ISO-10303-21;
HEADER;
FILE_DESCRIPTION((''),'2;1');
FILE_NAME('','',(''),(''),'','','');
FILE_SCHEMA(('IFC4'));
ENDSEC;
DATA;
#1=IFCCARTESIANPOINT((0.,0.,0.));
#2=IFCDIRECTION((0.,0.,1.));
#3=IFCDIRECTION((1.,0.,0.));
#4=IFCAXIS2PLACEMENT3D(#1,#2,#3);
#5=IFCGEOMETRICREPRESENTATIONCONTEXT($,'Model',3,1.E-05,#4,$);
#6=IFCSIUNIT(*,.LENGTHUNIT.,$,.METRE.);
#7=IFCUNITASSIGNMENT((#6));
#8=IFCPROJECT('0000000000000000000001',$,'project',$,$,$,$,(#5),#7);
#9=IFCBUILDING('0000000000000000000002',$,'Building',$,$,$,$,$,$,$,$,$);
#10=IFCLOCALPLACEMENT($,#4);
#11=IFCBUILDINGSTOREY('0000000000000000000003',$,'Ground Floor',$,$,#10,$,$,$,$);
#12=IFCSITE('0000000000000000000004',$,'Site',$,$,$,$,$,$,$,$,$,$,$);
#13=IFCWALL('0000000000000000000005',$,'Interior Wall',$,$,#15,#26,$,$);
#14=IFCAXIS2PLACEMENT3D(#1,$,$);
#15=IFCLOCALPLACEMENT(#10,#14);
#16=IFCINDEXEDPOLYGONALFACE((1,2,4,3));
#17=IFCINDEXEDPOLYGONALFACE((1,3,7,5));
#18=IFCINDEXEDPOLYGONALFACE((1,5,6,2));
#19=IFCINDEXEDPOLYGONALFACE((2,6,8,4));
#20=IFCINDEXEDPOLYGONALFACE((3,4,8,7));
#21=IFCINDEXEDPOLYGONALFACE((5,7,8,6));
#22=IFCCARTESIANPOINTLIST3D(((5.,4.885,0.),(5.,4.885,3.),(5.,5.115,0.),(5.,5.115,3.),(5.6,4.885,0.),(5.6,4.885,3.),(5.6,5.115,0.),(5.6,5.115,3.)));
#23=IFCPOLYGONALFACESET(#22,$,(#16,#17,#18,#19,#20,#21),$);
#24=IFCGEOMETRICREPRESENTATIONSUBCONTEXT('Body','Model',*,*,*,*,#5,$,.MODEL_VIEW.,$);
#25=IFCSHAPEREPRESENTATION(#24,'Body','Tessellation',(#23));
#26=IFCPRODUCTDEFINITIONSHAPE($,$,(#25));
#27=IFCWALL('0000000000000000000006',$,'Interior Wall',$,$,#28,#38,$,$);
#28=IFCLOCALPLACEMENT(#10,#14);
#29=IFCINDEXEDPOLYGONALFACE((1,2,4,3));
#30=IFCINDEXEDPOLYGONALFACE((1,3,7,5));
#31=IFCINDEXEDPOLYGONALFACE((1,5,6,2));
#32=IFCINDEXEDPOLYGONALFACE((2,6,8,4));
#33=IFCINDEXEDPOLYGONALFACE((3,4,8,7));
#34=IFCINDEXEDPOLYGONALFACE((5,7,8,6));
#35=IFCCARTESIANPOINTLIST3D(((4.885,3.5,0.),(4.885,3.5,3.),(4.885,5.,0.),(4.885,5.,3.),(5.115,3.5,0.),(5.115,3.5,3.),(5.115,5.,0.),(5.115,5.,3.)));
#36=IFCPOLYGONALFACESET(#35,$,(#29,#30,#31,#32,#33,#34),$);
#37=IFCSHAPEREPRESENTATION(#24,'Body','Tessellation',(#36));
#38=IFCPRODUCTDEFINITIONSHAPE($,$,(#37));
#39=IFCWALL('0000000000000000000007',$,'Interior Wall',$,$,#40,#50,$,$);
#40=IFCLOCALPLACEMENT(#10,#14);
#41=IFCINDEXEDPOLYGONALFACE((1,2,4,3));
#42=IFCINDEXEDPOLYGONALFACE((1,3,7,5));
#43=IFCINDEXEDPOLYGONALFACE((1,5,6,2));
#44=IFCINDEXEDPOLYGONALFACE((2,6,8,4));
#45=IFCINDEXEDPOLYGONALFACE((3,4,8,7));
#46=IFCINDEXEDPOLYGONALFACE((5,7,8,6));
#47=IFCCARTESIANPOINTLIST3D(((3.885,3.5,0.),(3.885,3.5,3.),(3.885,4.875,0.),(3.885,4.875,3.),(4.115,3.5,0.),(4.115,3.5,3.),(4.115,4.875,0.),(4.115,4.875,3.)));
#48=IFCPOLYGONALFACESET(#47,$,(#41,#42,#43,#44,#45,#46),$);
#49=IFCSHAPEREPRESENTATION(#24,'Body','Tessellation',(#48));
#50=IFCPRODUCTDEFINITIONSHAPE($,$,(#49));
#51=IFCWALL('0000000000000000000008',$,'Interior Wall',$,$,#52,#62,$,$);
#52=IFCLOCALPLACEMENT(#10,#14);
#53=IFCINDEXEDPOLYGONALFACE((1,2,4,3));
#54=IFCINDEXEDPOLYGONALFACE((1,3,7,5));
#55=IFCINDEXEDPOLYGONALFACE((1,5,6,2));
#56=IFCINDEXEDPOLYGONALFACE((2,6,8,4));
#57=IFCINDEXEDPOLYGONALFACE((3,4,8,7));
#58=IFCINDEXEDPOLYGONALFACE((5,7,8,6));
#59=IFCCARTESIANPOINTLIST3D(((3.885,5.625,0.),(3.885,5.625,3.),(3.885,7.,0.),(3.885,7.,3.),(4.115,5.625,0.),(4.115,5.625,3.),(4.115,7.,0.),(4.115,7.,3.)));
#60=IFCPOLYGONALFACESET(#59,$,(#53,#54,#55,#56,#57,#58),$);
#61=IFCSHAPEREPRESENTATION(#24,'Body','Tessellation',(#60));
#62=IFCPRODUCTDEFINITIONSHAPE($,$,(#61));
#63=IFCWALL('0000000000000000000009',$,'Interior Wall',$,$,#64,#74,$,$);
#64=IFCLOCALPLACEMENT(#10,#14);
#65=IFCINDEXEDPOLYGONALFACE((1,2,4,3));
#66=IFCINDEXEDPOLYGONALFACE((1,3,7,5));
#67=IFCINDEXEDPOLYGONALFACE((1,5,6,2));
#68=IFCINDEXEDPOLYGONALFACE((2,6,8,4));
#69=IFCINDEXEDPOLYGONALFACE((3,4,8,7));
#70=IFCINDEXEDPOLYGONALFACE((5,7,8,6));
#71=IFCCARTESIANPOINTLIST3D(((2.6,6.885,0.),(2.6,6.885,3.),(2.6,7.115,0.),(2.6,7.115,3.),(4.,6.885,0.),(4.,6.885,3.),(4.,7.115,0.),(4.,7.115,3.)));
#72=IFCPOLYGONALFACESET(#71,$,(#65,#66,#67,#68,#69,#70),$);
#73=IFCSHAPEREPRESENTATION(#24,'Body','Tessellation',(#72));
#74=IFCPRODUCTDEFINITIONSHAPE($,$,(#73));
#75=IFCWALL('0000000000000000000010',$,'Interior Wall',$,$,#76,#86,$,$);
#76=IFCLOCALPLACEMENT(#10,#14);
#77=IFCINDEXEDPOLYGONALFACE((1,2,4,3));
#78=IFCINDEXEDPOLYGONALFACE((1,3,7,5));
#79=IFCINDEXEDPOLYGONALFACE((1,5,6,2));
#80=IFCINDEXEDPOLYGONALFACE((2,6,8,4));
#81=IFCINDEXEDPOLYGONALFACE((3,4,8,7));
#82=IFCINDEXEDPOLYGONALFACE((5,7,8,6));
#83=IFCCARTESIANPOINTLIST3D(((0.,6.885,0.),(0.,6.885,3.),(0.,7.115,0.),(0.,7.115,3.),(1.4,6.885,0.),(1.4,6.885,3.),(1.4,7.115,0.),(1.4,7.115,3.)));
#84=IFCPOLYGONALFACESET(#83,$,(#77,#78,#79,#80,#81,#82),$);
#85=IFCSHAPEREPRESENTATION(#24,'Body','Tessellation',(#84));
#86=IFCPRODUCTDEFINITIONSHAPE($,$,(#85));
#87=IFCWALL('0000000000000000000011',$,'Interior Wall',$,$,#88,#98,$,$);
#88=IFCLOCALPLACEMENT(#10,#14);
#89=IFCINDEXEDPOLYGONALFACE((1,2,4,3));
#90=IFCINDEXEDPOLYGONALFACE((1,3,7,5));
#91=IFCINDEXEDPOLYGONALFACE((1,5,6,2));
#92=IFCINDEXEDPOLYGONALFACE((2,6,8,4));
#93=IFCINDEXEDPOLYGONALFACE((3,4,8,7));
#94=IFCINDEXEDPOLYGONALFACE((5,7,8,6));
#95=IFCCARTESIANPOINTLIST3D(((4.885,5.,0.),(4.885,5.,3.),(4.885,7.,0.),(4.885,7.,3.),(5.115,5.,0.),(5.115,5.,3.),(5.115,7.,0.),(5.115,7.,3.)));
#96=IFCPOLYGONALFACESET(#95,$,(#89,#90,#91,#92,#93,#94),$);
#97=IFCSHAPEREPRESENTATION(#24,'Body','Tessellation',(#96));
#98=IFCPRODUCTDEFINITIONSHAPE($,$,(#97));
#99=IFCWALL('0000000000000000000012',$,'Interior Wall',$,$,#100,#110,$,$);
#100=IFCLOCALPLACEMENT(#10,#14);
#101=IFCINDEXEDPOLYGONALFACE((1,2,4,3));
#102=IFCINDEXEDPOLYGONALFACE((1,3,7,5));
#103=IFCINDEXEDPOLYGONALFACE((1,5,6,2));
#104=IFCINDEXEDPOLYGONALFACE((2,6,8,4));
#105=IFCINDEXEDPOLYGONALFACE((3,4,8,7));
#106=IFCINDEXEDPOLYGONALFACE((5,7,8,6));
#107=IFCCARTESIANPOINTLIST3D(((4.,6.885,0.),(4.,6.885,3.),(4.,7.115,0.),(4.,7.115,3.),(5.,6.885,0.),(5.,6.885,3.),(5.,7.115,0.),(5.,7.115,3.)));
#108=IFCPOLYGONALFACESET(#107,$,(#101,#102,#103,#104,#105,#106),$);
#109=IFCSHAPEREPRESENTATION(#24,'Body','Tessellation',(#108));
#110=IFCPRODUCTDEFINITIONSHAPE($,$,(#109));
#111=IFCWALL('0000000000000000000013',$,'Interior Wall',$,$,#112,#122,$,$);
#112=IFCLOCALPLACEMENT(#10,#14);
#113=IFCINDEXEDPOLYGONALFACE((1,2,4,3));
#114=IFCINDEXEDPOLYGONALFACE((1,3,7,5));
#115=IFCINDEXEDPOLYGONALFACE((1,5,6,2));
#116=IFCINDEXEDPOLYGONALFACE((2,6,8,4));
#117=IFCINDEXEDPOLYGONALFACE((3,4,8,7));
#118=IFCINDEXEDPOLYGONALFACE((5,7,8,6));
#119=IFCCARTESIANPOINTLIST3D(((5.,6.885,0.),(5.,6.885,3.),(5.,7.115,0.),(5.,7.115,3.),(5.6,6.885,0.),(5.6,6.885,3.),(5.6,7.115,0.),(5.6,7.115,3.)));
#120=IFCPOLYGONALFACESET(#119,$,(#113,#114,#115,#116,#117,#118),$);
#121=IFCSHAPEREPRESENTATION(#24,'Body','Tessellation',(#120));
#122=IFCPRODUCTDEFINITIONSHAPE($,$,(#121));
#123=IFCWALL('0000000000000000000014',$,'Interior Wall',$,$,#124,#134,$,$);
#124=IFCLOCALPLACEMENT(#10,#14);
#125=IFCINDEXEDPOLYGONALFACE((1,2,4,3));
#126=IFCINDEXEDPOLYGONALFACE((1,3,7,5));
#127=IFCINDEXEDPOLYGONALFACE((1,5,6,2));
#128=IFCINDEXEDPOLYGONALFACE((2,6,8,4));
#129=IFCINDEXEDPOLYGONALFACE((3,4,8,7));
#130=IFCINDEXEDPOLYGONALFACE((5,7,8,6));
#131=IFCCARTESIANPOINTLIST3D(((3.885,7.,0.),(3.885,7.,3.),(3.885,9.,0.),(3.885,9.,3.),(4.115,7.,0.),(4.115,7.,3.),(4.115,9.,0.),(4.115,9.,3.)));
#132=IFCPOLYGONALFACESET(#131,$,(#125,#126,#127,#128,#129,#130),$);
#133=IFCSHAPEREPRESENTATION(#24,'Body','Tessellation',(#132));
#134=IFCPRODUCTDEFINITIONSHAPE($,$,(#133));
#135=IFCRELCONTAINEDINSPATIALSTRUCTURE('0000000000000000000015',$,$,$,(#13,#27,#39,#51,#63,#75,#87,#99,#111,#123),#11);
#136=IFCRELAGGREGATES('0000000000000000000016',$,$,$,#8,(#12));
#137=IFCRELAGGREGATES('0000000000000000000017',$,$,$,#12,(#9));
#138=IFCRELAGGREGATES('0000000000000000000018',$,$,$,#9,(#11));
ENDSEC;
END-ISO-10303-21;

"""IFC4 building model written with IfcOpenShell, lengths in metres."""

from ifc_helpers import new_model, si_unit, frame, origin_with_axes, place, context, subcontext, project, spatial, indexed_curve, outline, extrude, element, save


model = new_model("IFC4")

# Units and contexts
model_context = context("Model", 3, precision=1e-05, world=origin_with_axes())
body_context = subcontext(model_context, "Body", "Model", "MODEL_VIEW")
ifc_project = project(units=[si_unit("LENGTHUNIT", "METRE")], contexts=[model_context])

# Site, building, storey
site = spatial("IfcSite", under=ifc_project, Name="Site")
building = spatial("IfcBuilding", under=site, Name="Building")
storey_placement = place(None, origin_with_axes())
storey = spatial("IfcBuildingStorey", under=building, at=storey_placement, Name="Ground Floor")

# Walls
wall_1_placement = place(storey_placement, frame((5.6, 5.0, 0.0), z_axis=(0.0, 0.0, 1.0), x_axis=(-1.0, 0.0, 0.0)))
element("IfcWall", 1, at=wall_1_placement, inside=storey, Name="Interior Wall", context=body_context, shape_type="SweptSolid", body=[
    extrude(outline(indexed_curve([(0.0, 0.0), (0.0, 0.23), (0.6, 0.23), (0.6, 0.0), (0.0, 0.0)], self_intersect=False)), frame((0.0, -0.115, 0.0), z_axis=(0.0, 0.0, 1.0), x_axis=(1.0, 0.0, 0.0)), (0.0, 0.0, 1.0), 3.0),
])
wall_2_placement = place(storey_placement, frame((5.0, 5.0, 0.0), z_axis=(0.0, 0.0, 1.0), x_axis=(0.0, -1.0, 0.0)))
element("IfcWall", 2, at=wall_2_placement, inside=storey, Name="Interior Wall", context=body_context, shape_type="SweptSolid", body=[
    extrude(outline(indexed_curve([(0.0, 0.0), (0.0, 0.23), (1.5, 0.23), (1.5, 0.0), (0.0, 0.0)], self_intersect=False)), frame((0.0, -0.115, 0.0), z_axis=(0.0, 0.0, 1.0), x_axis=(1.0, 0.0, 0.0)), (0.0, 0.0, 1.0), 3.0),
])
for number, where, z_axis, x_axis, name in (
    (3, (4.0, 3.5, 0.0), (0.0, 0.0, 1.0), (0.0, 1.0, 0.0), "Interior Wall"),
    (4, (4.0, 5.625, 0.0), (0.0, 0.0, 1.0), (0.0, 1.0, 0.0), "Interior Wall"),
):
    element("IfcWall", number, at=place(storey_placement, frame(where, z_axis=z_axis, x_axis=x_axis)), inside=storey, Name=name, context=body_context, shape_type="SweptSolid", body=[
        extrude(outline(indexed_curve([(0.0, 0.0), (0.0, 0.23), (1.375, 0.23), (1.375, 0.0), (0.0, 0.0)], self_intersect=False)), frame((0.0, -0.115, 0.0), z_axis=(0.0, 0.0, 1.0), x_axis=(1.0, 0.0, 0.0)), (0.0, 0.0, 1.0), 3.0),
    ])
for number, where, z_axis, x_axis, name in (
    (5, (4.0, 7.0, 0.0), (0.0, 0.0, 1.0), (-1.0, 0.0, 0.0), "Interior Wall"),
    (6, (1.4, 7.0, 0.0), (0.0, 0.0, 1.0), (-1.0, 0.0, 0.0), "Interior Wall"),
):
    element("IfcWall", number, at=place(storey_placement, frame(where, z_axis=z_axis, x_axis=x_axis)), inside=storey, Name=name, context=body_context, shape_type="SweptSolid", body=[
        extrude(outline(indexed_curve([(0.0, 0.0), (0.0, 0.23), (1.4, 0.23), (1.4, 0.0), (0.0, 0.0)], self_intersect=False)), frame((0.0, -0.115, 0.0), z_axis=(0.0, 0.0, 1.0), x_axis=(1.0, 0.0, 0.0)), (0.0, 0.0, 1.0), 3.0),
    ])
wall_3_placement = place(storey_placement, frame((5.0, 5.0, 0.0), z_axis=(0.0, 0.0, 1.0), x_axis=(0.0, 1.0, 0.0)))
element("IfcWall", 7, at=wall_3_placement, inside=storey, Name="Interior Wall", context=body_context, shape_type="SweptSolid", body=[
    extrude(outline(indexed_curve([(0.0, 0.0), (0.0, 0.23), (2.0, 0.23), (2.0, 0.0), (0.0, 0.0)], self_intersect=False)), frame((0.0, -0.115, 0.0), z_axis=(0.0, 0.0, 1.0), x_axis=(1.0, 0.0, 0.0)), (0.0, 0.0, 1.0), 3.0),
])
wall_4_placement = place(storey_placement, frame((5.0, 7.0, 0.0), z_axis=(0.0, 0.0, 1.0), x_axis=(-1.0, 0.0, 0.0)))
element("IfcWall", 8, at=wall_4_placement, inside=storey, Name="Interior Wall", context=body_context, shape_type="SweptSolid", body=[
    extrude(outline(indexed_curve([(0.0, 0.0), (0.0, 0.23), (1.0, 0.23), (1.0, 0.0), (0.0, 0.0)], self_intersect=False)), frame((0.0, -0.115, 0.0), z_axis=(0.0, 0.0, 1.0), x_axis=(1.0, 0.0, 0.0)), (0.0, 0.0, 1.0), 3.0),
])
wall_5_placement = place(storey_placement, frame((5.6, 7.0, 0.0), z_axis=(0.0, 0.0, 1.0), x_axis=(-1.0, 0.0, 0.0)))
element("IfcWall", 9, at=wall_5_placement, inside=storey, Name="Interior Wall", context=body_context, shape_type="SweptSolid", body=[
    extrude(outline(indexed_curve([(0.0, 0.0), (0.0, 0.23), (0.6, 0.23), (0.6, 0.0), (0.0, 0.0)], self_intersect=False)), frame((0.0, -0.115, 0.0), z_axis=(0.0, 0.0, 1.0), x_axis=(1.0, 0.0, 0.0)), (0.0, 0.0, 1.0), 3.0),
])
wall_6_placement = place(storey_placement, frame((4.0, 7.0, 0.0), z_axis=(0.0, 0.0, 1.0), x_axis=(0.0, 1.0, 0.0)))
element("IfcWall", 10, at=wall_6_placement, inside=storey, Name="Interior Wall", context=body_context, shape_type="SweptSolid", body=[
    extrude(outline(indexed_curve([(0.0, 0.0), (0.0, 0.23), (2.0, 0.23), (2.0, 0.0), (0.0, 0.0)], self_intersect=False)), frame((0.0, -0.115, 0.0), z_axis=(0.0, 0.0, 1.0), x_axis=(1.0, 0.0, 0.0)), (0.0, 0.0, 1.0), 3.0),
])

save(model, "model.ifc")
